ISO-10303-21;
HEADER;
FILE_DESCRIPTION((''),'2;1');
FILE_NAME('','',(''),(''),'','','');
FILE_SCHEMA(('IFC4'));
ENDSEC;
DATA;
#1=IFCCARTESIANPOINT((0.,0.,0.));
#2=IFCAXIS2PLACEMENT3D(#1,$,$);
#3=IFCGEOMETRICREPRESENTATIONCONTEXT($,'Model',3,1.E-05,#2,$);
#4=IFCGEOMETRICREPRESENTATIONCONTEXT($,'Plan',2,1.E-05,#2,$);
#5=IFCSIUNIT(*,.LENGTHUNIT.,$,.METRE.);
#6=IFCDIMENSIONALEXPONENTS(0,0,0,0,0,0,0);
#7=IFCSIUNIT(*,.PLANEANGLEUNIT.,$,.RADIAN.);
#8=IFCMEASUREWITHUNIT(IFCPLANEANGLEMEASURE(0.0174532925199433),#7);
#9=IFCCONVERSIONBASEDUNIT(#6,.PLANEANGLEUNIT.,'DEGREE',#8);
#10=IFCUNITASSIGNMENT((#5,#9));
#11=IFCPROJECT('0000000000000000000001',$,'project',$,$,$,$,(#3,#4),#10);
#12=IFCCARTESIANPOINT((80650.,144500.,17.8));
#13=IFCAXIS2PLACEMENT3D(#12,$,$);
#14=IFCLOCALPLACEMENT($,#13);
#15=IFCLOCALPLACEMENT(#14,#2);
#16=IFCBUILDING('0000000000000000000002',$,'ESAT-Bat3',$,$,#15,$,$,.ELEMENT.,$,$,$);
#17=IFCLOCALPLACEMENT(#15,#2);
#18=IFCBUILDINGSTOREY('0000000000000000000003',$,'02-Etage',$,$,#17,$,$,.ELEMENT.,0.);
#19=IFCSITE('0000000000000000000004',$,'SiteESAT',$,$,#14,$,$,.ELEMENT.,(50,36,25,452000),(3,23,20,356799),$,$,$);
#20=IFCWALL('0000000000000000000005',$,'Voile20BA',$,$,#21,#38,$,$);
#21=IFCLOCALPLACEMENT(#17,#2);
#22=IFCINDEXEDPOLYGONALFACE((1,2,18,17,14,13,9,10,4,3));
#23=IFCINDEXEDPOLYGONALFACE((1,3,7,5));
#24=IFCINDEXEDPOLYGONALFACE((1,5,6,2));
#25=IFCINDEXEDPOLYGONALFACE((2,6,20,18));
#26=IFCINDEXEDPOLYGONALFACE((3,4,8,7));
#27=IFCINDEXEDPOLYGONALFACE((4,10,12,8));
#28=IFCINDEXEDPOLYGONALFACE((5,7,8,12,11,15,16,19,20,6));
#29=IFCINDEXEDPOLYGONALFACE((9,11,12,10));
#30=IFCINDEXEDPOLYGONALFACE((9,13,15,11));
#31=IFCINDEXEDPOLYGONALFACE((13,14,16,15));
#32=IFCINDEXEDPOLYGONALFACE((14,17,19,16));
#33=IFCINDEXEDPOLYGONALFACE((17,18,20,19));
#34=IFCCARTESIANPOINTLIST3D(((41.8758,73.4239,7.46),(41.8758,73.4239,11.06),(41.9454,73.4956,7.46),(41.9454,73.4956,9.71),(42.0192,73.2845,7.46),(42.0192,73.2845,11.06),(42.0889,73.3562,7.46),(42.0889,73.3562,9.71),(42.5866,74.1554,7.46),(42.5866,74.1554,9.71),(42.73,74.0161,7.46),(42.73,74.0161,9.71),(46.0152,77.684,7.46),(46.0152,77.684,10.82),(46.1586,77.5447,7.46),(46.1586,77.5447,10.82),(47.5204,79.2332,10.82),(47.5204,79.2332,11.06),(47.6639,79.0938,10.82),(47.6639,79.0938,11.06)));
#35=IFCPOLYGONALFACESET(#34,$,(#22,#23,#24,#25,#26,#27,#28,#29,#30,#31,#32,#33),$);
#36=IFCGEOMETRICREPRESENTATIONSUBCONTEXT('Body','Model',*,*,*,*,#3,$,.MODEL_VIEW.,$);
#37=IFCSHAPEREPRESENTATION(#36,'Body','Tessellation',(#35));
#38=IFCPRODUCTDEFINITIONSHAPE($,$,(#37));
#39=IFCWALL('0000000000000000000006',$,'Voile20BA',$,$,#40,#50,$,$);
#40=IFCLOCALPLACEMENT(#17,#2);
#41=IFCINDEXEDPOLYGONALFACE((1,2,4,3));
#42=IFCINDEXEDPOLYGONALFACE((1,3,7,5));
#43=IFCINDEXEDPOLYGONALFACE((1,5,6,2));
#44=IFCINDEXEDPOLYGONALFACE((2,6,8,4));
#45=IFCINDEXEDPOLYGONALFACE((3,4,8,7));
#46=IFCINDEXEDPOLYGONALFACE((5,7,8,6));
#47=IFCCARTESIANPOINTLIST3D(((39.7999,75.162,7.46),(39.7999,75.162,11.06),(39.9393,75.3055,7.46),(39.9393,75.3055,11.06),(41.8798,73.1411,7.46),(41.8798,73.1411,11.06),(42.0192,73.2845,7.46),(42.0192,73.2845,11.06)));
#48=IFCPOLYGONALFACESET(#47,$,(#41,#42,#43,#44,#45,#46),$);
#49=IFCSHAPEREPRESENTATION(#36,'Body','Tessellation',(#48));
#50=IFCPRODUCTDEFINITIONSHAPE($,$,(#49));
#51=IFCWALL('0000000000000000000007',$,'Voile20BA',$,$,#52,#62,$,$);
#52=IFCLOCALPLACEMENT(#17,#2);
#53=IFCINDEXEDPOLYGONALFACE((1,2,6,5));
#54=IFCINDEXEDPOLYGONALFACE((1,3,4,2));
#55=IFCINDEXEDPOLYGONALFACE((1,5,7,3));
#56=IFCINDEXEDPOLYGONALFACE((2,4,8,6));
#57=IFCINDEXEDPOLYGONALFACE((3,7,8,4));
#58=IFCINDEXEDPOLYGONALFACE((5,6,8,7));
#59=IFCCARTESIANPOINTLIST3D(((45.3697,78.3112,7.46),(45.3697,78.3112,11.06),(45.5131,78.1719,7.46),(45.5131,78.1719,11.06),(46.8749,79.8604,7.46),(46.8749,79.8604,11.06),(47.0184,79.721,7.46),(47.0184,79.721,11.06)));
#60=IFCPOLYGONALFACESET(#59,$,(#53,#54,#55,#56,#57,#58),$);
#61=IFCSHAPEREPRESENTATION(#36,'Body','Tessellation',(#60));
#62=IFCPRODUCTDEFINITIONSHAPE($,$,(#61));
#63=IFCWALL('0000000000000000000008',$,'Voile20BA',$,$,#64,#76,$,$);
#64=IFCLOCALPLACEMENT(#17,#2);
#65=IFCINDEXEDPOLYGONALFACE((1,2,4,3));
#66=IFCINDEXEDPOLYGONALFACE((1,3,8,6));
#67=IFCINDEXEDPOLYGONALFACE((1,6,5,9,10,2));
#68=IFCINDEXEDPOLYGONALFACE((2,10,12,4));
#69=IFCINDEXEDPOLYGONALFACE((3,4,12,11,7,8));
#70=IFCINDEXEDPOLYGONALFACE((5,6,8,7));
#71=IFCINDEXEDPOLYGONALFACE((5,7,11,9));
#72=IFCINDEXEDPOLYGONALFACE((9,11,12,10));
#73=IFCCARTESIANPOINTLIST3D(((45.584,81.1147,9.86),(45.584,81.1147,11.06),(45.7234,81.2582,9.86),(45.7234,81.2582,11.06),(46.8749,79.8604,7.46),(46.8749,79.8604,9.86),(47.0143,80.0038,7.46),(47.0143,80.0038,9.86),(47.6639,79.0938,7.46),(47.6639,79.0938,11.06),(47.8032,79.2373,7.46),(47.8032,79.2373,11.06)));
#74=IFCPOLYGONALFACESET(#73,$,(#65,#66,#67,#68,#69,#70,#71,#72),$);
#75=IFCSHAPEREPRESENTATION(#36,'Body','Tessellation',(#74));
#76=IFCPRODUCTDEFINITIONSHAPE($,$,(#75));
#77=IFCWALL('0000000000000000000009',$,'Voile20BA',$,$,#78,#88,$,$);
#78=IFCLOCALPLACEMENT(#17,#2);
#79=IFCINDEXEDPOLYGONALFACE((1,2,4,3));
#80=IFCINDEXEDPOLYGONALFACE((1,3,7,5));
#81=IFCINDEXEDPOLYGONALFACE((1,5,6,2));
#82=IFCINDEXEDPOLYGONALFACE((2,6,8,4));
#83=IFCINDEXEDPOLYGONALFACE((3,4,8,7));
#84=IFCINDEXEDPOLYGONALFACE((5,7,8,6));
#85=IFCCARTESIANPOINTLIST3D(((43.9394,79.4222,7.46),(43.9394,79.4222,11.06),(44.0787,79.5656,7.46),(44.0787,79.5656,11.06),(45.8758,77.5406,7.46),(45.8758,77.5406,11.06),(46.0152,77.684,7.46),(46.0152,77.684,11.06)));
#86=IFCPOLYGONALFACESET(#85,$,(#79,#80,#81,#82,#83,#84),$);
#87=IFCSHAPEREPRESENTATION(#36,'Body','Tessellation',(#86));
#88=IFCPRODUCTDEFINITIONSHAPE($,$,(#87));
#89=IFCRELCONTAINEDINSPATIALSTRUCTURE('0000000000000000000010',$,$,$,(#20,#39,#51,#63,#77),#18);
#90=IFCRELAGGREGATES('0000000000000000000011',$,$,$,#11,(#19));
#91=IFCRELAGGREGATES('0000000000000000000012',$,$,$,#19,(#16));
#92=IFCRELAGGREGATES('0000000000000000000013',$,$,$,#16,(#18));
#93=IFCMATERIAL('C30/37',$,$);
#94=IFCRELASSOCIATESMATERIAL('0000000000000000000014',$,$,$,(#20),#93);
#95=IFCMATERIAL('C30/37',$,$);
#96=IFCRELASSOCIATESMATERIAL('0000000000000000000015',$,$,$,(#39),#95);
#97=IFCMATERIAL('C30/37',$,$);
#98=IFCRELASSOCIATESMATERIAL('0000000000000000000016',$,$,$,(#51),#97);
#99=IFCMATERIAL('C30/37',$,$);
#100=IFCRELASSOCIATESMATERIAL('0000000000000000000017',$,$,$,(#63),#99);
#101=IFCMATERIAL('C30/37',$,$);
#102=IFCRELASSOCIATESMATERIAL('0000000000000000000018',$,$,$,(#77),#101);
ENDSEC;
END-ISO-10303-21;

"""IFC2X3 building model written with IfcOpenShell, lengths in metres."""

from ifc_helpers import new_model, entity, si_unit, converted_unit, frame, frame_2d, origin, origin_with_axes, place, context, subcontext, project, spatial, polyline, rectangle, outline, extrude, material, element, save


model = new_model("IFC2X3")

# Units and contexts
model_context = context("Model", 3, precision=1e-05, world=origin())
plan_context = context("Plan", 2, precision=1e-05, world=origin())
body_context = subcontext(model_context, "Body", "Model", "MODEL_VIEW")
ifc_project = project(units=[si_unit("LENGTHUNIT", "METRE"), converted_unit("PLANEANGLEUNIT", "DEGREE", entity("IfcPlaneAngleMeasure", 0.0174532925199433), si_unit("PLANEANGLEUNIT", "RADIAN"), dimensions=[0, 0, 0, 0, 0, 0, 0])], contexts=[model_context, plan_context])

# Site, building, storey
site_placement = place(None, frame((80650.0, 144500.0, 17.8)))
site = spatial("IfcSite", under=ifc_project, at=site_placement, Name="SiteESAT", CompositionType="ELEMENT", RefLatitude=(50, 36, 25, 452000), RefLongitude=(3, 23, 20, 356799))
building_placement = place(site_placement, origin())
building = spatial("IfcBuilding", under=site, at=building_placement, Name="ESAT-Bat3", CompositionType="ELEMENT")
storey_placement = place(building_placement, origin())
storey = spatial("IfcBuildingStorey", under=building, at=storey_placement, Name="02-Etage", CompositionType="ELEMENT", Elevation=0.0)

# Wall, openings
ifc_material_1 = material(Name="C30/37")
wall_1_placement = place(storey_placement, frame((47.5204, 79.2332, 7.46), z_axis=(0.0, 0.0, 1.0), x_axis=(-0.696872, -0.717196, 0.0)))
wall_1 = element("IfcWall", 1, at=wall_1_placement, inside=storey, material=ifc_material_1, Name="Voile20BA", context=body_context, shape_type="SweptSolid", body=[
    extrude(rectangle(XDim=8.1, YDim=0.2, at=frame_2d((4.05, 0.1), x_axis=(1.0, 0.0))), origin_with_axes(), (0.0, 0.0, 1.0), 3.6),
])
opening_1_placement = place(wall_1_placement, frame((2.16, 0.2, 0.0), z_axis=(0.0, -1.0, 0.0), x_axis=(0.0, 0.0, 1.0)))
element("IfcOpeningElement", 2, at=opening_1_placement, cuts=wall_1, ObjectType="Opening", context=body_context, shape_type="SweptSolid", body=[
    extrude(outline(polyline([(0.0, 2.16), (3.36, 2.16), (3.36, 0.0), (0.0, 0.0), (0.0, 2.16)])), origin_with_axes(), (0.0, 0.0, 1.0), 0.2),
])
opening_2_placement = place(wall_1_placement, frame((8.0, 0.2, 0.0), z_axis=(0.0, -1.0, 0.0), x_axis=(0.0, 0.0, 1.0)))
element("IfcOpeningElement", 3, at=opening_2_placement, cuts=wall_1, ObjectType="Opening", context=body_context, shape_type="SweptSolid", body=[
    extrude(outline(polyline([(0.0, 0.92), (2.25, 0.92), (2.25, 0.0), (0.0, 0.0), (0.0, 0.92)])), origin_with_axes(), (0.0, 0.0, 1.0), 0.2),
])

# Walls
ifc_material_2 = material(Name="C30/37")
wall_2_placement = place(storey_placement, frame((39.7999, 75.162, 7.46), z_axis=(0.0, 0.0, 1.0), x_axis=(0.717196, -0.696872, 0.0)))
element("IfcWall", 4, at=wall_2_placement, inside=storey, material=ifc_material_2, Name="Voile20BA", context=body_context, shape_type="SweptSolid", body=[
    extrude(rectangle(XDim=2.9, YDim=0.2, at=frame_2d((1.45, 0.1), x_axis=(1.0, 0.0))), origin_with_axes(), (0.0, 0.0, 1.0), 3.6),
])
ifc_material_3 = material(Name="C30/37")
wall_3_placement = place(storey_placement, frame((45.5131, 78.1719, 7.46), z_axis=(0.0, 0.0, 1.0), x_axis=(0.696872, 0.717196, 0.0)))
element("IfcWall", 5, at=wall_3_placement, inside=storey, material=ifc_material_3, Name="Voile20BA", context=body_context, shape_type="SweptSolid", body=[
    extrude(rectangle(XDim=2.16, YDim=0.2, at=frame_2d((1.08, 0.1), x_axis=(1.0, 0.0))), origin_with_axes(), (0.0, 0.0, 1.0), 3.6),
])

# Wall, opening
ifc_material_4 = material(Name="C30/37")
wall_4_placement = place(storey_placement, frame((45.584, 81.1147, 7.46), z_axis=(0.0, 0.0, 1.0), x_axis=(0.717196, -0.696872, 0.0)))
wall_4 = element("IfcWall", 6, at=wall_4_placement, inside=storey, material=ifc_material_4, Name="Voile20BA", context=body_context, shape_type="SweptSolid", body=[
    extrude(rectangle(XDim=2.9, YDim=0.2, at=frame_2d((1.45, 0.1), x_axis=(1.0, 0.0))), origin_with_axes(), (0.0, 0.0, 1.0), 3.6),
])
opening_3_placement = place(wall_4_placement, frame((1.8, 0.2, 0.0), z_axis=(0.0, -1.0, 0.0), x_axis=(0.0, 0.0, 1.0)))
element("IfcOpeningElement", 7, at=opening_3_placement, cuts=wall_4, ObjectType="Opening", context=body_context, shape_type="SweptSolid", body=[
    extrude(outline(polyline([(0.0, 1.8), (2.4, 1.8), (2.4, 0.0), (0.0, 0.0), (0.0, 1.8)])), origin_with_axes(), (0.0, 0.0, 1.0), 0.2),
])

# Wall
ifc_material_5 = material(Name="C30/37")
wall_5_placement = place(storey_placement, frame((46.0152, 77.684, 7.46), z_axis=(0.0, 0.0, 1.0), x_axis=(-0.717196, 0.696872, 0.0)))
element("IfcWall", 8, at=wall_5_placement, inside=storey, material=ifc_material_5, Name="Voile20BA", context=body_context, shape_type="SweptSolid", body=[
    extrude(rectangle(XDim=2.7, YDim=0.2, at=frame_2d((1.35, 0.1), x_axis=(1.0, 0.0))), origin_with_axes(), (0.0, 0.0, 1.0), 3.6),
])

save(model, "model.ifc")
